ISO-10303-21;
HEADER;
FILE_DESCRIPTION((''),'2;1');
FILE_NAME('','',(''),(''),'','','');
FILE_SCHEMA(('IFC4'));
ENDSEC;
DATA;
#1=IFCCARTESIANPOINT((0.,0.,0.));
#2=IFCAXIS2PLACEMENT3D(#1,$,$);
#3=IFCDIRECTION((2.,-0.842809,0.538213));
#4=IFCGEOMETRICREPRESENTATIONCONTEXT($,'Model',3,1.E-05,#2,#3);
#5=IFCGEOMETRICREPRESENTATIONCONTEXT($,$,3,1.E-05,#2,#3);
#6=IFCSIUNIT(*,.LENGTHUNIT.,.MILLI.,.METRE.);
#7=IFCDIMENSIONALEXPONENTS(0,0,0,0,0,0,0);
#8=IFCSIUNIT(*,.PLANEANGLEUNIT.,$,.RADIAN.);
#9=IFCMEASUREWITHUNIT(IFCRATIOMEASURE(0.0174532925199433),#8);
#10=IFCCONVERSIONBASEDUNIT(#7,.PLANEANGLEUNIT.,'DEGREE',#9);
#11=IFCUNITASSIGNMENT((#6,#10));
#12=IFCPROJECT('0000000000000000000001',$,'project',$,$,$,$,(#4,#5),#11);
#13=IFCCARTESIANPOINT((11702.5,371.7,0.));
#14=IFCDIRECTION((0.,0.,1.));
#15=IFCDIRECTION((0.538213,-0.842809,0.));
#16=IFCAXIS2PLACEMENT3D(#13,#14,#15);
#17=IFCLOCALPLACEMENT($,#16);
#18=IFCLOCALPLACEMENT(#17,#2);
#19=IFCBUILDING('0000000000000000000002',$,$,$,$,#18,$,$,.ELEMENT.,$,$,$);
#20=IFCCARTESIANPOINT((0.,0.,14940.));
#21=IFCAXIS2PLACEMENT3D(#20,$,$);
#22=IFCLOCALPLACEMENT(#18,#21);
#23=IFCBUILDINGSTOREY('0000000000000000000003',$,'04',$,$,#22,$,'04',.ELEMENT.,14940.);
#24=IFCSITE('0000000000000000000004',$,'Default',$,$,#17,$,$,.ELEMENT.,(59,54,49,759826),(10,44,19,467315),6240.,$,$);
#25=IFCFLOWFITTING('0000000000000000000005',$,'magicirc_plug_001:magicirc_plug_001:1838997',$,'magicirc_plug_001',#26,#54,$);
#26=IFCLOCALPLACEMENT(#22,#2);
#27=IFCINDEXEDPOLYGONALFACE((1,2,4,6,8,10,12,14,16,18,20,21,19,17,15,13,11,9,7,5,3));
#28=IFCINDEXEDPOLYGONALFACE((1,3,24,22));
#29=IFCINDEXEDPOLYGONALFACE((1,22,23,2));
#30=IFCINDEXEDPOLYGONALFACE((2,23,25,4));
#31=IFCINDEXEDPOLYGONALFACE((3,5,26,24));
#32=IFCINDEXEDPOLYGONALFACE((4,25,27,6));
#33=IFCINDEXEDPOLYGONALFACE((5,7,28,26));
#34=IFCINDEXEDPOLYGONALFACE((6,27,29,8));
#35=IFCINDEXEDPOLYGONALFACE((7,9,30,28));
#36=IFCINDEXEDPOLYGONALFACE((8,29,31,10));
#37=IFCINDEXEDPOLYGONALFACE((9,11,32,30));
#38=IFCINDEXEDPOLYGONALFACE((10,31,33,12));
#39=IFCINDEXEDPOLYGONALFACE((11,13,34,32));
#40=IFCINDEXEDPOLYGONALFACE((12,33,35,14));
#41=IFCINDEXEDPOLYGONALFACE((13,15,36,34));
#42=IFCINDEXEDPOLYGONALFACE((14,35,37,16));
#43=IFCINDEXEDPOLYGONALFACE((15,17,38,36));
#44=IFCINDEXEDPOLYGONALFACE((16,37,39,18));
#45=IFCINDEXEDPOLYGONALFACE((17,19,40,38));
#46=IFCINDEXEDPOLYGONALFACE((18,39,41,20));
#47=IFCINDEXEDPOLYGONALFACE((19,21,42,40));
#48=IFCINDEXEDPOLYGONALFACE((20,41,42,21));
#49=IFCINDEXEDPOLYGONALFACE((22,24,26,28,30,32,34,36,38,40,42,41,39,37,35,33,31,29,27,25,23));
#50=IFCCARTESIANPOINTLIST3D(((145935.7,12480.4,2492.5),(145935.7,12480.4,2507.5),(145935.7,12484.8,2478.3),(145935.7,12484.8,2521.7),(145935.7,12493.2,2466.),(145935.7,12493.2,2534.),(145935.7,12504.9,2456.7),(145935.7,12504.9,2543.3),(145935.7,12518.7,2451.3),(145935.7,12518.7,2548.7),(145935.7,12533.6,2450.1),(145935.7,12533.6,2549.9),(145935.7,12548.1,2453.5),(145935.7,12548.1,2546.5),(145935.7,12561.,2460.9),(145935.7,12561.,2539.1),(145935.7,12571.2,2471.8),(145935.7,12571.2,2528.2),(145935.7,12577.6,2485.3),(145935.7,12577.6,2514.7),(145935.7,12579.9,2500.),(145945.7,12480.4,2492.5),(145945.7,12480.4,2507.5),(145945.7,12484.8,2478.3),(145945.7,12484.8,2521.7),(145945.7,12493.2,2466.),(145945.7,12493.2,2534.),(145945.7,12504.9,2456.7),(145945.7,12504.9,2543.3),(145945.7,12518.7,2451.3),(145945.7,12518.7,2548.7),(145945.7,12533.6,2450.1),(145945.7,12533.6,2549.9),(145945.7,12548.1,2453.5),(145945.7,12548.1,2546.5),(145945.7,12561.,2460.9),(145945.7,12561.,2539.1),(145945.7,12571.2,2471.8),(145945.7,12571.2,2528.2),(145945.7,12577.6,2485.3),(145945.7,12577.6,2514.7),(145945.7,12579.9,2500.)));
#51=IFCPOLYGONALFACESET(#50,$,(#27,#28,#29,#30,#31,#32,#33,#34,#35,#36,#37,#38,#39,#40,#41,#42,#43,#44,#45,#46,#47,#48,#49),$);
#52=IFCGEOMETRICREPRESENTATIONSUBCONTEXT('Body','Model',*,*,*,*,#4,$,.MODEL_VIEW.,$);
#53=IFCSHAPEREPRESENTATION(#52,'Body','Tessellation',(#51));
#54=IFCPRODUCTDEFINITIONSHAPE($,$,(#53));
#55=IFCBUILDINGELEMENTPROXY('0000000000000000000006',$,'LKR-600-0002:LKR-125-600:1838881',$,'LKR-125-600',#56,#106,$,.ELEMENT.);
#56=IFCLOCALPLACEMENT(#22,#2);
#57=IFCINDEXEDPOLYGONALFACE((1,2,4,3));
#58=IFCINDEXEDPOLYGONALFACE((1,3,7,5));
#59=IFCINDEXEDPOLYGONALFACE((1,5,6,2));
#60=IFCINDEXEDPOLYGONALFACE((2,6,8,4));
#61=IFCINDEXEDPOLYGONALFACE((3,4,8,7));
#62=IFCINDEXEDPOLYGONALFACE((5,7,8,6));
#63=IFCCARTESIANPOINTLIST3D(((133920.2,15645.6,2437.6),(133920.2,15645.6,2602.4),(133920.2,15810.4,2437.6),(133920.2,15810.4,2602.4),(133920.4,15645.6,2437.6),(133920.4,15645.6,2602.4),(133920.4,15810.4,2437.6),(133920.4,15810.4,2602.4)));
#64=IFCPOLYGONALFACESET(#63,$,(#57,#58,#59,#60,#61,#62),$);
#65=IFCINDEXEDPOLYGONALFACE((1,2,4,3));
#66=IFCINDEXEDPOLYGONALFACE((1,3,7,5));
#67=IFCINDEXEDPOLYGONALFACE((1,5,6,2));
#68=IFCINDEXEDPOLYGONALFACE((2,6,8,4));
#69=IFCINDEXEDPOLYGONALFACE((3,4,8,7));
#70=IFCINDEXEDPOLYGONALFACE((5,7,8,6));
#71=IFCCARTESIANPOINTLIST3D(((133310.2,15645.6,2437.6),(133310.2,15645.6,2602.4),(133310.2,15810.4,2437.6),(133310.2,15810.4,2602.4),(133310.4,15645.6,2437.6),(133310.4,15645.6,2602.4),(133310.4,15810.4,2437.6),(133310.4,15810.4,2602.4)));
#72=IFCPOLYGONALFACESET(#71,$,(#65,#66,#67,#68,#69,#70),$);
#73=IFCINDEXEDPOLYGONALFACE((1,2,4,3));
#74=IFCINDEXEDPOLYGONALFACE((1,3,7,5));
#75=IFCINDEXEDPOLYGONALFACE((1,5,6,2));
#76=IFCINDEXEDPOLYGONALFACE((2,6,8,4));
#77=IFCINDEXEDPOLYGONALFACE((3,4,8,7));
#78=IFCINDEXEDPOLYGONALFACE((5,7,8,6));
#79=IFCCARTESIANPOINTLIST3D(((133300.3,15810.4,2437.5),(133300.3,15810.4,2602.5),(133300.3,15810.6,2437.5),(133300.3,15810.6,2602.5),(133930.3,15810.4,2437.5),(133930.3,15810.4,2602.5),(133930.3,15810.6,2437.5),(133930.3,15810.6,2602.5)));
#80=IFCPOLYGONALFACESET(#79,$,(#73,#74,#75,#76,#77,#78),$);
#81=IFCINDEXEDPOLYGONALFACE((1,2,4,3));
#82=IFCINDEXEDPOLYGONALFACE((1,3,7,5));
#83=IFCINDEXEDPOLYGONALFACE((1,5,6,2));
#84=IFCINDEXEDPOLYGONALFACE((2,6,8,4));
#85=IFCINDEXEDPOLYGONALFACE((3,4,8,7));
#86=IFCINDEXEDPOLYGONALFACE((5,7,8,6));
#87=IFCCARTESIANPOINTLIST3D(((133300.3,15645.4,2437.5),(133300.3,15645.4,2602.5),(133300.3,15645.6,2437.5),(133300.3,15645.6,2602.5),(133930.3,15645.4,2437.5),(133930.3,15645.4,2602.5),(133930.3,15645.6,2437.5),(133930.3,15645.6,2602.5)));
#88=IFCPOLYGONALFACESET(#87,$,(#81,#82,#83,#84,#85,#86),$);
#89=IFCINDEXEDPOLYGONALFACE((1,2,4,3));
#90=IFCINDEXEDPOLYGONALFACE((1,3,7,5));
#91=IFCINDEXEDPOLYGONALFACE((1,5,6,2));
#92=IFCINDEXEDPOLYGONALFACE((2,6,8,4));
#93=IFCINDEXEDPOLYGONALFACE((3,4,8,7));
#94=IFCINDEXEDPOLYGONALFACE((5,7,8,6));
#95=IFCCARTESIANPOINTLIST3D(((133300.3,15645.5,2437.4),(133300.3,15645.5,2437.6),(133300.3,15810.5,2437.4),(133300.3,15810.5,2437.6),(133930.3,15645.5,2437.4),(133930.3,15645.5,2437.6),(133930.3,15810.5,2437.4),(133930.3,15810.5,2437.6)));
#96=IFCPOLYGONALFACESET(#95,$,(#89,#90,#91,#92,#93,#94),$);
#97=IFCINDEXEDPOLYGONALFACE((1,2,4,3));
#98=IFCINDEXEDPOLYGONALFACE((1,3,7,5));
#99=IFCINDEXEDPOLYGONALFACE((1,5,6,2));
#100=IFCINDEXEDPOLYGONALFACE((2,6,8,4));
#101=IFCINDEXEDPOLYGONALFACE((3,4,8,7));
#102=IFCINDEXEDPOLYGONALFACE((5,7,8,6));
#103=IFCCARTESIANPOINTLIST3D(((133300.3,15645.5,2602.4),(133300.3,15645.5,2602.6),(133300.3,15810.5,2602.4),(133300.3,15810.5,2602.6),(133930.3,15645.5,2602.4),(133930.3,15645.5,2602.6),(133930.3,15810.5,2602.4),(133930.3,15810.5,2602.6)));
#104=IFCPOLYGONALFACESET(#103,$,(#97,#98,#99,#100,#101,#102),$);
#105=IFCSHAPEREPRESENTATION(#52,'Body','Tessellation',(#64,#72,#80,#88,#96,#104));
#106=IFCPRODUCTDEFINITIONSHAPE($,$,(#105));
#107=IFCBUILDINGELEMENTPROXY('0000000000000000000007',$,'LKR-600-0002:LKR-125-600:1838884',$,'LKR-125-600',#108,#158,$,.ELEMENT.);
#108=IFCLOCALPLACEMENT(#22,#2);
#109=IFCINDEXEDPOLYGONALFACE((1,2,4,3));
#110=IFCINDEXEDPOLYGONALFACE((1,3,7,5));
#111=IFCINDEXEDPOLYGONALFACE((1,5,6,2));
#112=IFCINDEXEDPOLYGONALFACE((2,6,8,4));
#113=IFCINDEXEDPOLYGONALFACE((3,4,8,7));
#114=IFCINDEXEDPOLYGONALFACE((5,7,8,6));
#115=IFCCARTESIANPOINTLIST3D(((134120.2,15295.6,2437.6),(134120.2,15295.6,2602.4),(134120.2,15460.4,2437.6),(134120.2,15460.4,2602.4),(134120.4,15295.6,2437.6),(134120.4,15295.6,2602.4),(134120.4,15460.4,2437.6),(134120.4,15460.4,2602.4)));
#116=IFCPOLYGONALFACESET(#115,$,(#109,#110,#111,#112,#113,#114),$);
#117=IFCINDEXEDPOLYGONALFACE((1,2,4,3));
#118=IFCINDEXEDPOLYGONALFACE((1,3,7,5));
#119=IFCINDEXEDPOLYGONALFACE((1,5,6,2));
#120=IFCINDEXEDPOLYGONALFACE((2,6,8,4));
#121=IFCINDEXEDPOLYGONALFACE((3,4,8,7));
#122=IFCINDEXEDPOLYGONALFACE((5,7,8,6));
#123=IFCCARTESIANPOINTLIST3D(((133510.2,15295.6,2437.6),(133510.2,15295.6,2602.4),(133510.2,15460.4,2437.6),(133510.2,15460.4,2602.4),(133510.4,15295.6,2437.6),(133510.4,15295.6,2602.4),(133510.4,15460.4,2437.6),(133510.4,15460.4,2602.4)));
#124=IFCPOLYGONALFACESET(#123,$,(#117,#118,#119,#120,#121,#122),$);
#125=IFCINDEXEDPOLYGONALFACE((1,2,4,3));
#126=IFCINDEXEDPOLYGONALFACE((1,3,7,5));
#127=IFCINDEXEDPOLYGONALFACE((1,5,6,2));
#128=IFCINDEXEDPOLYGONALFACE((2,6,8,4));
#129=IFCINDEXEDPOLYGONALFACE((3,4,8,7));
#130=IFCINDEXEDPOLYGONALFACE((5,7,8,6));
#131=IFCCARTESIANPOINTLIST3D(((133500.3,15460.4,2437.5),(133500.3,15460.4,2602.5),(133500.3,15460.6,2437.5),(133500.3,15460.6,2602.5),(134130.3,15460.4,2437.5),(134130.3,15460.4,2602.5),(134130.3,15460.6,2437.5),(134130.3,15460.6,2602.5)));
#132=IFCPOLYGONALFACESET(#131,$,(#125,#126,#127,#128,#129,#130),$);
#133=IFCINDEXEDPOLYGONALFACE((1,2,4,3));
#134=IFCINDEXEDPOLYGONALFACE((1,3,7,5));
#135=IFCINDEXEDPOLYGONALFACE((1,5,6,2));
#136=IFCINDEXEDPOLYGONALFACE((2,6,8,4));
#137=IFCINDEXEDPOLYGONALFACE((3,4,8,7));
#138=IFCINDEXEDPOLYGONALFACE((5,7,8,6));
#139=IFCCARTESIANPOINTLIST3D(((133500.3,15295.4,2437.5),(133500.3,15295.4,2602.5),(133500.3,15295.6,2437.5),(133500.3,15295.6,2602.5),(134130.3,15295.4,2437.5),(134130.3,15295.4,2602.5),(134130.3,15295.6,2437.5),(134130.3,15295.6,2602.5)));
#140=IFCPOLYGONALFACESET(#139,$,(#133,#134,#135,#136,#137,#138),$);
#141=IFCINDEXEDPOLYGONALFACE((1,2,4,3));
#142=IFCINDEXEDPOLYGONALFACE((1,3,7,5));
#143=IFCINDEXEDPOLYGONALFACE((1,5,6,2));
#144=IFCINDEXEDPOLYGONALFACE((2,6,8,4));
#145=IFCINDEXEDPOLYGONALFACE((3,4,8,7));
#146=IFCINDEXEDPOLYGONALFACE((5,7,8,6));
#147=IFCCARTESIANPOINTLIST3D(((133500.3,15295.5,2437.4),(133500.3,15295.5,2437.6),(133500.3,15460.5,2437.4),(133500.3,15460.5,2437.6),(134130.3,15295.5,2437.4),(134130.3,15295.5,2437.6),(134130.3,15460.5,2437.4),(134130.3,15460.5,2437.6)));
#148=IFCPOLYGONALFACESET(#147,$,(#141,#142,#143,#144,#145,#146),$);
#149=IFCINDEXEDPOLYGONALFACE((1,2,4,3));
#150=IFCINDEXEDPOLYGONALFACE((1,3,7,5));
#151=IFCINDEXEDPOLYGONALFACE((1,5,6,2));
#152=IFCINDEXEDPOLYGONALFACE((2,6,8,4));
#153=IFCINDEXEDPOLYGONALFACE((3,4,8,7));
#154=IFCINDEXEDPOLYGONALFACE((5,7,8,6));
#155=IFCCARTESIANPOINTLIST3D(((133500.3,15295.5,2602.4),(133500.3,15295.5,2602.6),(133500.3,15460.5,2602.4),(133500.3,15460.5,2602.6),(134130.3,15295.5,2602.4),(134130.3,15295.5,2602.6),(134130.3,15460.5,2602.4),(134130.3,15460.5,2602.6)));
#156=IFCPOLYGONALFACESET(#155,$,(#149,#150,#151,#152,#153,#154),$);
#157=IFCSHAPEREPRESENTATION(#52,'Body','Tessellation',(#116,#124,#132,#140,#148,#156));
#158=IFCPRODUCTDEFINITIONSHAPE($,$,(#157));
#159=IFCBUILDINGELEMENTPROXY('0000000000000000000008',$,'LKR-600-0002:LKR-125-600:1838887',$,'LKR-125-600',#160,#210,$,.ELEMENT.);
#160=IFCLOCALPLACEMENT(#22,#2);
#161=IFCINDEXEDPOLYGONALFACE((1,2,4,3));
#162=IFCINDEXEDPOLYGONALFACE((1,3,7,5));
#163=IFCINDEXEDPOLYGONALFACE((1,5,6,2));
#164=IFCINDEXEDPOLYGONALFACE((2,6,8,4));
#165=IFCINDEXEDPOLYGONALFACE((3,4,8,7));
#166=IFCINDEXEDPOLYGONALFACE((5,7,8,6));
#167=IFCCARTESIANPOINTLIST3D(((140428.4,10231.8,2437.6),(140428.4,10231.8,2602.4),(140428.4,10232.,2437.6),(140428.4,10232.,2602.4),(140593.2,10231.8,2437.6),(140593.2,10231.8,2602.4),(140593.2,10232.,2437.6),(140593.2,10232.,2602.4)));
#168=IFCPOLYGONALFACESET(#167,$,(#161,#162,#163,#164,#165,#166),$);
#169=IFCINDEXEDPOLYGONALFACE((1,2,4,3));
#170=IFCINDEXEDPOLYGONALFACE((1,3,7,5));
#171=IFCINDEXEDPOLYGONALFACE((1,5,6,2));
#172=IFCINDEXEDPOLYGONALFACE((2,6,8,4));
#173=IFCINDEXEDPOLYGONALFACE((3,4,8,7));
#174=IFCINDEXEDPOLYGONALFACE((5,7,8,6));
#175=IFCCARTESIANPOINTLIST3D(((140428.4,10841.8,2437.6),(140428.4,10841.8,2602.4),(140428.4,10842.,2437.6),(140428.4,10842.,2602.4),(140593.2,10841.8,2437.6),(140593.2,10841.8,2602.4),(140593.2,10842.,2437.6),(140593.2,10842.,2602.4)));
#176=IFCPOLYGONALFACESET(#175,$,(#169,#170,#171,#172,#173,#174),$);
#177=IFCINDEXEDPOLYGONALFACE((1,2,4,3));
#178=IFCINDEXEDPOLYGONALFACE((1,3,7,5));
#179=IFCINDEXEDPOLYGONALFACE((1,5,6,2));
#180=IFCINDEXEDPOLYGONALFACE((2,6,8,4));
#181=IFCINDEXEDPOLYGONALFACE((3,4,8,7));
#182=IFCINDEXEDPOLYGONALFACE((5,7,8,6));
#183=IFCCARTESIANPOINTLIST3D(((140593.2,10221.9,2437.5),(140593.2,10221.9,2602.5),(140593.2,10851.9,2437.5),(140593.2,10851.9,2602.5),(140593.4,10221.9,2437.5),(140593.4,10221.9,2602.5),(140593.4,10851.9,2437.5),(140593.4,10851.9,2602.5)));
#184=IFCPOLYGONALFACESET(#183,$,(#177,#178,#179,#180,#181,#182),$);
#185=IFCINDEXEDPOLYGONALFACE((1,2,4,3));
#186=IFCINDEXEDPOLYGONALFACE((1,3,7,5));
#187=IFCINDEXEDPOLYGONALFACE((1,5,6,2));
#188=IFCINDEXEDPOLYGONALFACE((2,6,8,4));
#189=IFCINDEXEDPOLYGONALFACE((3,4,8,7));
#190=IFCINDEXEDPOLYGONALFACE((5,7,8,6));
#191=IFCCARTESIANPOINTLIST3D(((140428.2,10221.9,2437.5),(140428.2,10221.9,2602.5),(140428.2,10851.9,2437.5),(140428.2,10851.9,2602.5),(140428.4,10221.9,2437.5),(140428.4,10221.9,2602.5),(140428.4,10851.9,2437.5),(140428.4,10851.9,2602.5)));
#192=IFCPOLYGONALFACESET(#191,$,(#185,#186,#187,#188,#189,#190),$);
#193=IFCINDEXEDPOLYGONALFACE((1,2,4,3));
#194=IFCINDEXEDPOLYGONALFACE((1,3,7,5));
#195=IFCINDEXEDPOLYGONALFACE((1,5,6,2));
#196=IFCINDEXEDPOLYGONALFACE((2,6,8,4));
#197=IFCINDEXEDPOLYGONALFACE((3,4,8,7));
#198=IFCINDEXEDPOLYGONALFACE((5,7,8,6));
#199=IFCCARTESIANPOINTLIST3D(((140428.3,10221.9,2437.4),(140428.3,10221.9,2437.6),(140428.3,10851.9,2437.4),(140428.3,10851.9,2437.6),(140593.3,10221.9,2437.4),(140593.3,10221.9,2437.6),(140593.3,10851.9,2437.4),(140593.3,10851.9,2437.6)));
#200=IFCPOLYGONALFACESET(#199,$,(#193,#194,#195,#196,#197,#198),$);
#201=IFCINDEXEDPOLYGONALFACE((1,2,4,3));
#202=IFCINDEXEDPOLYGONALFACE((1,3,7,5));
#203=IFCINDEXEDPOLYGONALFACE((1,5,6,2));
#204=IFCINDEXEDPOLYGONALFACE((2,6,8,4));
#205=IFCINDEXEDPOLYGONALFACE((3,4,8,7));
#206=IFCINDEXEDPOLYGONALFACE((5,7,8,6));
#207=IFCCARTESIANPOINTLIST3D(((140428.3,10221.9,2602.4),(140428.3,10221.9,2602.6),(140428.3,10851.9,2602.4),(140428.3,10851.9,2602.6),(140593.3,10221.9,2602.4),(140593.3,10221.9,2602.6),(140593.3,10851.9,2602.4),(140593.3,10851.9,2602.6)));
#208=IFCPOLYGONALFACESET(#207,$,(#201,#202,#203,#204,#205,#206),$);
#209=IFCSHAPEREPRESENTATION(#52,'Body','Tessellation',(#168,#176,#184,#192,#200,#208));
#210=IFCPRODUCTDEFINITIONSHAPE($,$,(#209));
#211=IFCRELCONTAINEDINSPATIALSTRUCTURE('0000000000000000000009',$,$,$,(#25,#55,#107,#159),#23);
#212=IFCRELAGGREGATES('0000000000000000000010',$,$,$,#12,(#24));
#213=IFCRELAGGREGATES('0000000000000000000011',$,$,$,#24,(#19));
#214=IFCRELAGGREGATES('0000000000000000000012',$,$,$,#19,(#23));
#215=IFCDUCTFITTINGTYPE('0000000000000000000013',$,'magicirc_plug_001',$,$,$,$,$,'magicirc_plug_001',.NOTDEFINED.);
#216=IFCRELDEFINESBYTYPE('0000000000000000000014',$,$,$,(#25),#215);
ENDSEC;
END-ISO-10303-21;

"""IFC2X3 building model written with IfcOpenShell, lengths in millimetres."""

from ifc_helpers import new_model, entity, si_unit, converted_unit, direction, frame, frame_2d, origin, place, context, subcontext, project, spatial, rectangle, circle, extrude, source, transform, mapped, type_object, type_shapes, element, save


model = new_model("IFC2X3")

# Units and contexts
model_context = context("Model", 3, precision=1e-05, world=origin(), true_north=direction((2.0, -0.842809, 0.538213)))
context_of_model = context(None, 3, precision=1e-05, world=origin(), true_north=direction((2.0, -0.842809, 0.538213)))
body_context = subcontext(model_context, "Body", "Model", "MODEL_VIEW")
ifc_project = project(units=[si_unit("LENGTHUNIT", "METRE", prefix="MILLI"), converted_unit("PLANEANGLEUNIT", "DEGREE", entity("IfcRatioMeasure", 0.0174532925199433), si_unit("PLANEANGLEUNIT", "RADIAN"), dimensions=[0, 0, 0, 0, 0, 0, 0])], contexts=[model_context, context_of_model])

# Site, building, storey
site_placement = place(None, frame((11702.5, 371.7, 0.0), z_axis=(0.0, 0.0, 1.0), x_axis=(0.538213, -0.842809, 0.0)))
site = spatial("IfcSite", under=ifc_project, at=site_placement, Name="Default", CompositionType="ELEMENT", RefLatitude=(59, 54, 49, 759826), RefLongitude=(10, 44, 19, 467315), RefElevation=6240.0)
building_placement = place(site_placement, origin())
building = spatial("IfcBuilding", under=site, at=building_placement, CompositionType="ELEMENT")
storey_placement = place(building_placement, frame((0.0, 0.0, 14940.0)))
storey = spatial("IfcBuildingStorey", under=building, at=storey_placement, Name="04", LongName="04", CompositionType="ELEMENT", Elevation=14940.0)

# Flow fitting
duct_fitting_type_1 = type_object("IfcDuctFittingType", Name="magicirc_plug_001", ElementType="magicirc_plug_001", PredefinedType="NOTDEFINED")
shared_shape_1 = source(origin(), body_context, "Body", "SweptSolid", [
    extrude(circle(Radius=50.0, at=frame_2d((0.0, 0.0), x_axis=(1.0, 0.0))), frame((0.0, 0.0, 0.0), z_axis=(1.0, 0.0, 0.0), x_axis=(0.0, 1.0, 0.0)), (0.0, 0.0, 1.0), 10.0),
])
type_shapes(duct_fitting_type_1, [shared_shape_1])
flow_fitting_1_placement = place(storey_placement, frame((145935.7, 12529.9, 2500.0)))
element("IfcFlowFitting", 1, at=flow_fitting_1_placement, inside=storey, type_object=duct_fitting_type_1, Name="magicirc_plug_001:magicirc_plug_001:1838997", ObjectType="magicirc_plug_001", context=body_context, shape_type="MappedRepresentation", body=[
    mapped(shared_shape_1, transform((0.0, 0.0, 0.0), scale=1.0)),
])

# Building element proxies
shared_shape_2 = source(origin(), body_context, "Body", "SweptSolid", [
    extrude(rectangle(XDim=0.2, YDim=164.8, at=frame_2d((0.0, 0.0), x_axis=(1.0, 0.0))), frame((305.0, 0.0, -82.4)), (0.0, 0.0, 1.0), 164.8),
    extrude(rectangle(XDim=0.2, YDim=164.8, at=frame_2d((0.0, 0.0), x_axis=(1.0, 0.0))), frame((-305.0, 0.0, -82.4)), (0.0, 0.0, 1.0), 164.8),
    extrude(rectangle(XDim=0.2, YDim=630.0, at=frame_2d((0.0, 0.0), x_axis=(1.0, 0.0))), frame((0.0, 82.5, -82.5), z_axis=(0.0, 0.0, 1.0), x_axis=(0.0, 1.0, 0.0)), (0.0, 0.0, 1.0), 165.0),
    extrude(rectangle(XDim=0.2, YDim=630.0, at=frame_2d((0.0, 0.0), x_axis=(1.0, 0.0))), frame((0.0, -82.5, -82.5), z_axis=(0.0, 0.0, 1.0), x_axis=(0.0, 1.0, 0.0)), (0.0, 0.0, 1.0), 165.0),
    extrude(rectangle(XDim=165.0, YDim=630.0, at=frame_2d((0.0, 0.0), x_axis=(1.0, 0.0))), frame((0.0, 0.0, -82.6), z_axis=(0.0, 0.0, 1.0), x_axis=(0.0, -1.0, 0.0)), (0.0, 0.0, 1.0), 0.2),
    extrude(rectangle(XDim=165.0, YDim=630.0, at=frame_2d((0.0, 0.0), x_axis=(1.0, 0.0))), frame((0.0, 0.0, 82.4), z_axis=(0.0, 0.0, 1.0), x_axis=(0.0, -1.0, 0.0)), (0.0, 0.0, 1.0), 0.2),
])
for number, where, name in (
    (2, (133615.3, 15728.0, 2520.0), "LKR-600-0002:LKR-125-600:1838881"),
    (3, (133815.3, 15378.0, 2520.0), "LKR-600-0002:LKR-125-600:1838884"),
):
    element("IfcBuildingElementProxy", number, at=place(storey_placement, frame(where)), inside=storey, Name=name, ObjectType="LKR-125-600", CompositionType="ELEMENT", context=body_context, shape_type="MappedRepresentation", body=[
        mapped(shared_shape_2, transform((0.0, 0.0, 0.0), scale=1.0)),
    ])
for number, where, z_axis, x_axis, name in (
    (4, (140510.8, 10536.9, 2520.0), (0.0, 0.0, 1.0), (0.0, -1.0, 0.0), "LKR-600-0002:LKR-125-600:1838887"),
):
    element("IfcBuildingElementProxy", number, at=place(storey_placement, frame(where, z_axis=z_axis, x_axis=x_axis)), inside=storey, Name=name, ObjectType="LKR-125-600", CompositionType="ELEMENT", context=body_context, shape_type="MappedRepresentation", body=[
        mapped(shared_shape_2, transform((0.0, 0.0, 0.0), scale=1.0)),
    ])

save(model, "model.ifc")
